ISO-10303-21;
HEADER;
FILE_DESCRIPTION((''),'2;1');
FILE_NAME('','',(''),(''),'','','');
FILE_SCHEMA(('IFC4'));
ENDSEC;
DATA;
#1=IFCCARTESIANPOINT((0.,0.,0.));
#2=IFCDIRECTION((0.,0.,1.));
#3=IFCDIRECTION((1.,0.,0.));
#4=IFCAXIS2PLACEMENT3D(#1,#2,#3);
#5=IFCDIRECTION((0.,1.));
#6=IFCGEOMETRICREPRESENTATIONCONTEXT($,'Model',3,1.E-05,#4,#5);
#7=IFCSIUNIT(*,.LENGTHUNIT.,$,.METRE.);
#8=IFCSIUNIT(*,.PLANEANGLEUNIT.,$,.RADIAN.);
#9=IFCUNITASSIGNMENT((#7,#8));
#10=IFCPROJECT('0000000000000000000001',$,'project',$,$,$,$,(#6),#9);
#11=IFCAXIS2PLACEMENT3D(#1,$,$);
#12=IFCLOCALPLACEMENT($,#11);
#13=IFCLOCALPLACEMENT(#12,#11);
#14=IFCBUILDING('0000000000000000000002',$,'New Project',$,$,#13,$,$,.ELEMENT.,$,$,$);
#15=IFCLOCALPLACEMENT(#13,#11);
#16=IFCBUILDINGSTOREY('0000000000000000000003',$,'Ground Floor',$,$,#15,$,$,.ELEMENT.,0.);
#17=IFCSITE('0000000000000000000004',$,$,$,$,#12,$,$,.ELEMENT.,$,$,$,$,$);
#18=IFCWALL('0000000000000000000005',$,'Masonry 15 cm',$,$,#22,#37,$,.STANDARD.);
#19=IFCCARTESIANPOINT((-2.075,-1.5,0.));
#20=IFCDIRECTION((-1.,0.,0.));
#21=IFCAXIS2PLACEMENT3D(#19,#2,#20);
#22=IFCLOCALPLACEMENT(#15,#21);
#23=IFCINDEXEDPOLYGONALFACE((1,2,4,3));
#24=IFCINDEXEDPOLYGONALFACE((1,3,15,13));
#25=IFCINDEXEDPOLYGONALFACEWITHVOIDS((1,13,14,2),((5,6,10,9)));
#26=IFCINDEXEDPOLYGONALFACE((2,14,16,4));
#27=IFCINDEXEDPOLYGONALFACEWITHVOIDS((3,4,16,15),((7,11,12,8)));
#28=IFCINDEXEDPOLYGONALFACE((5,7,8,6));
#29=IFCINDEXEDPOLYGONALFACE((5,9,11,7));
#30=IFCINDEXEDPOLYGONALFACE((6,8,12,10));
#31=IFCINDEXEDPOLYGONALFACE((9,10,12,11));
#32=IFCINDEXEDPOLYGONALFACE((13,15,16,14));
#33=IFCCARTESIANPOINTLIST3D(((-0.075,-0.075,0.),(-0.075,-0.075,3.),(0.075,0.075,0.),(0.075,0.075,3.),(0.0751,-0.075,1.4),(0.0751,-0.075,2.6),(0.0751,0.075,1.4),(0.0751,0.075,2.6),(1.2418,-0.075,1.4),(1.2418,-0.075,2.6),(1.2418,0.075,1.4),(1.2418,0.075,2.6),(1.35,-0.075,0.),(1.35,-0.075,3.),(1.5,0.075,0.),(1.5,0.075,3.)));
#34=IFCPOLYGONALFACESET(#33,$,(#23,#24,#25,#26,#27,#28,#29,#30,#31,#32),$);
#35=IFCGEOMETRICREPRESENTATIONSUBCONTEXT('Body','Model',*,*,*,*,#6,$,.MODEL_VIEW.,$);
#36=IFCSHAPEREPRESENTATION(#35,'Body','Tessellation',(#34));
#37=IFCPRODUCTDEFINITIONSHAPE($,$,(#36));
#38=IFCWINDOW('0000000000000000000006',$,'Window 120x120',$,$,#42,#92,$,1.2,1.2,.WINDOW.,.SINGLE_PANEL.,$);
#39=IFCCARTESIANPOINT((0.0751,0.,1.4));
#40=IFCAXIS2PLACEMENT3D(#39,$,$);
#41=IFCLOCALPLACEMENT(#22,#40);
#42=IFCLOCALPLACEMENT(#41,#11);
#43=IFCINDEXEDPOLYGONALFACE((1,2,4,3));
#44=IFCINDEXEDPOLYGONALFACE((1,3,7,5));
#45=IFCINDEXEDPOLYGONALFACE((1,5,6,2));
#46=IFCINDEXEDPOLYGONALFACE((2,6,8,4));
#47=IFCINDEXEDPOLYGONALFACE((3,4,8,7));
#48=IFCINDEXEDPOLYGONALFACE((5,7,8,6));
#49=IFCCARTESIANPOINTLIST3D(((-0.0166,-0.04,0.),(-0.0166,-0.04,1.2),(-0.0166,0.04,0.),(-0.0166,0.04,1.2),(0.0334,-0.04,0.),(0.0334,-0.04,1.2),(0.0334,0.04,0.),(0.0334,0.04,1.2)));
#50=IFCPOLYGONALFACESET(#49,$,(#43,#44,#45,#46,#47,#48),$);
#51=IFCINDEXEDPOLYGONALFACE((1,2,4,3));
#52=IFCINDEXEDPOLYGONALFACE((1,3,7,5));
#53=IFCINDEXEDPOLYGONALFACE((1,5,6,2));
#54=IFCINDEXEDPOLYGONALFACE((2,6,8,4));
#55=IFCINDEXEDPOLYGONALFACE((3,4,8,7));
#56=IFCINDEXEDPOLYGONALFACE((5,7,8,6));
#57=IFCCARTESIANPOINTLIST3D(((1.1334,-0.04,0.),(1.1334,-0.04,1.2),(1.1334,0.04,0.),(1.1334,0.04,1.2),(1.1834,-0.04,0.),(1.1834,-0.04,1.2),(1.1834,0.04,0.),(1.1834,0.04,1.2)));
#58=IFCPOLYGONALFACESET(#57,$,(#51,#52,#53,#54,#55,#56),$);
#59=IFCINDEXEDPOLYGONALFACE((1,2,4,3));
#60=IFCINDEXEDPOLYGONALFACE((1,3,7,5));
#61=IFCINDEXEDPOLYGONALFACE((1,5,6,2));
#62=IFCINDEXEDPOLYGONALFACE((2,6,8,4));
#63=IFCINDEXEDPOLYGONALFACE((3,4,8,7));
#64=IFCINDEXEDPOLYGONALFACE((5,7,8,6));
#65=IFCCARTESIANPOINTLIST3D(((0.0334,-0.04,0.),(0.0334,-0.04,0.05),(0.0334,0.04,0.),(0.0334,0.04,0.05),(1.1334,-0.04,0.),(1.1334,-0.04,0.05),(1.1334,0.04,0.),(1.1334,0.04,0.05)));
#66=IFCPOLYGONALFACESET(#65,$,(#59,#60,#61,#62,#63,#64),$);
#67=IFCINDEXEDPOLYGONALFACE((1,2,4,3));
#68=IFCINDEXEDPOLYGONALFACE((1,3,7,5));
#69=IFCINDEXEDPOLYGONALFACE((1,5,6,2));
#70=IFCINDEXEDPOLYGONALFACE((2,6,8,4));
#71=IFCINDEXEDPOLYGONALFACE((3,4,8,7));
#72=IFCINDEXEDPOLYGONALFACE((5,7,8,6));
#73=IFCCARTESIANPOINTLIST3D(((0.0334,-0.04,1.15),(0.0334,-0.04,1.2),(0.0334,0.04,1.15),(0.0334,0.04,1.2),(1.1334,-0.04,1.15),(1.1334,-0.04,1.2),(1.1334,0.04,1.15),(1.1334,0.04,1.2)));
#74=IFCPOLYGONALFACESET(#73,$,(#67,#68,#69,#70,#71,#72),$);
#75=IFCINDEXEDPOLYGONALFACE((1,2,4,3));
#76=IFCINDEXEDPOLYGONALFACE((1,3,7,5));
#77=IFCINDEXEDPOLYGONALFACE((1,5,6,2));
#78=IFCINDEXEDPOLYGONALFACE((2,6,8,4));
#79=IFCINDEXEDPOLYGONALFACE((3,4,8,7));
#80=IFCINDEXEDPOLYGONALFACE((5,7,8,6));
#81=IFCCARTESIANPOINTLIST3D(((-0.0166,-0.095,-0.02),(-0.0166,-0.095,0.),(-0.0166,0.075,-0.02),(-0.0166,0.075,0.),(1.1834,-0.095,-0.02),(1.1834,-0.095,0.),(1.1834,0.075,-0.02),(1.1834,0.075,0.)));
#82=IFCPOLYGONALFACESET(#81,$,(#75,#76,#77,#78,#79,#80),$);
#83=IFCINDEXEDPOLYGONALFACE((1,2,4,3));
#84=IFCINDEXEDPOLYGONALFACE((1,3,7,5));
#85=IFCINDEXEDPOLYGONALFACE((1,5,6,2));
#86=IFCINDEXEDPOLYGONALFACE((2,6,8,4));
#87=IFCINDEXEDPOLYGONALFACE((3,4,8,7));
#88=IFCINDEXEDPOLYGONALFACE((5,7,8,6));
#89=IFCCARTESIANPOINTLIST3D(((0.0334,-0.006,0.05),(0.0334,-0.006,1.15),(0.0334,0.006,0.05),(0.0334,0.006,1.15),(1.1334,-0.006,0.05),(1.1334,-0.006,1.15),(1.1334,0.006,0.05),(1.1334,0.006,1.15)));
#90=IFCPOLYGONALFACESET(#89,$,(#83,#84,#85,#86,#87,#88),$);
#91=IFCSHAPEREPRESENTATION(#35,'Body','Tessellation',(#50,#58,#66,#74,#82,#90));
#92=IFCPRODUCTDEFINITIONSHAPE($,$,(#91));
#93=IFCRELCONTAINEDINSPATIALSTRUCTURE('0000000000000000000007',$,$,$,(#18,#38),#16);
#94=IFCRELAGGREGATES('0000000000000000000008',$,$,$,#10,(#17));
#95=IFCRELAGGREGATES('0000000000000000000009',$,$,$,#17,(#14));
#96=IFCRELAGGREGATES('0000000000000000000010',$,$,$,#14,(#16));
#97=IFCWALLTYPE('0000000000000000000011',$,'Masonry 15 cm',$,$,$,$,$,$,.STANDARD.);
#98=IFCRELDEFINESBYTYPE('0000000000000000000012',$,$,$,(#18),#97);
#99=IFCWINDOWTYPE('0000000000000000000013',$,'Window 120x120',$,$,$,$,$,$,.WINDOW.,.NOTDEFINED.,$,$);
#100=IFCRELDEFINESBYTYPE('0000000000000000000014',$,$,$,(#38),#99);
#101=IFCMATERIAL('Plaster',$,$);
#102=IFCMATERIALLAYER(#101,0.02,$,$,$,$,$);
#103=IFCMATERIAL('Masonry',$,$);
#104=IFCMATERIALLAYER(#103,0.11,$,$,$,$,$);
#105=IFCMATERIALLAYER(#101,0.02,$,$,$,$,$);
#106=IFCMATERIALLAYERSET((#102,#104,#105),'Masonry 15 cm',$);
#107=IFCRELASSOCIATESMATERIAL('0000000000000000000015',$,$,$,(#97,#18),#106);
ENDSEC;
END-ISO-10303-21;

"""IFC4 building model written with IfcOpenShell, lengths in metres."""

from ifc_helpers import new_model, si_unit, direction, frame, frame_2d, origin, origin_with_axes, place, context, subcontext, project, spatial, polyline, rectangle, outline, extrude, material, layer, layer_set, layer_usage, type_object, element, fill, save


model = new_model("IFC4")

# Units and contexts
model_context = context("Model", 3, precision=1e-05, world=origin_with_axes(), true_north=direction((0.0, 1.0)))
body_context = subcontext(model_context, "Body", "Model", "MODEL_VIEW")
ifc_project = project(units=[si_unit("LENGTHUNIT", "METRE"), si_unit("PLANEANGLEUNIT", "RADIAN")], contexts=[model_context])

# Site, building, storey
site_placement = place(None, origin())
site = spatial("IfcSite", under=ifc_project, at=site_placement, CompositionType="ELEMENT")
building_placement = place(site_placement, origin())
building = spatial("IfcBuilding", under=site, at=building_placement, Name="New Project", CompositionType="ELEMENT")
storey_placement = place(building_placement, origin())
storey = spatial("IfcBuildingStorey", under=building, at=storey_placement, Name="Ground Floor", CompositionType="ELEMENT", Elevation=0.0)

# Shared definitions
ifc_material_1 = material(Name="Plaster")
ifc_layer_1 = layer(ifc_material_1, 0.02)
ifc_material_2 = material(Name="Masonry")
ifc_layer_2 = layer(ifc_material_2, 0.11)
ifc_layer_3 = layer(ifc_material_1, 0.02)
ifc_layer_set_1 = layer_set([ifc_layer_1, ifc_layer_2, ifc_layer_3], Name="Masonry 15 cm")
ifc_layer_usage_1 = layer_usage(ifc_layer_set_1, "AXIS2", "NEGATIVE", 0.075)
wall_type = type_object("IfcWallType", Name="Masonry 15 cm", PredefinedType="STANDARD", material=ifc_layer_set_1)
window_type = type_object("IfcWindowType", Name="Window 120x120", PartitioningType="NOTDEFINED", PredefinedType="WINDOW")

# Wall, opening, window
wall_1_placement = place(storey_placement, frame((-2.075, -1.5, 0.0), z_axis=(0.0, 0.0, 1.0), x_axis=(-1.0, 0.0, 0.0)))
wall_1 = element("IfcWall", 1, at=wall_1_placement, inside=storey, type_object=wall_type, material=ifc_layer_usage_1, Name="Masonry 15 cm", PredefinedType="STANDARD", context=body_context, shape_type="SweptSolid", body=[
    extrude(outline(polyline([(-0.075, -0.075), (1.35, -0.075), (1.5, 0.075), (0.075, 0.075), (-0.075, -0.075)])), origin(), (0.0, 0.0, 1.0), 3.0),
])
opening_1_placement = place(wall_1_placement, frame((0.0751, 0.0, 1.4)))
opening_1 = element("IfcOpeningElement", 2, at=opening_1_placement, cuts=wall_1, PredefinedType="OPENING", context=body_context, shape_type="SweptSolid", body=[
    extrude(rectangle(XDim=1.1667, YDim=0.25, at=frame_2d((0.5834, 0.0))), origin(), (0.0, 0.0, 1.0), 1.2),
])
window_1_placement = place(opening_1_placement, origin())
window_1 = element("IfcWindow", 3, at=window_1_placement, inside=storey, type_object=window_type, Name="Window 120x120", OverallHeight=1.2, OverallWidth=1.2, PartitioningType="SINGLE_PANEL", PredefinedType="WINDOW", context=body_context, shape_type="SweptSolid", body=[
    extrude(outline(polyline([(-0.0166, -0.04), (0.0334, -0.04), (0.0334, 0.04), (-0.0166, 0.04), (-0.0166, -0.04)])), origin(), (0.0, 0.0, 1.0), 1.2),
    extrude(outline(polyline([(1.1334, -0.04), (1.1834, -0.04), (1.1834, 0.04), (1.1334, 0.04), (1.1334, -0.04)])), origin(), (0.0, 0.0, 1.0), 1.2),
    extrude(outline(polyline([(0.0334, -0.04), (1.1334, -0.04), (1.1334, 0.04), (0.0334, 0.04), (0.0334, -0.04)])), origin(), (0.0, 0.0, 1.0), 0.05),
    extrude(outline(polyline([(0.0334, -0.04), (1.1334, -0.04), (1.1334, 0.04), (0.0334, 0.04), (0.0334, -0.04)])), frame((0.0, 0.0, 1.15)), (0.0, 0.0, 1.0), 0.05),
    extrude(outline(polyline([(-0.0166, -0.095), (1.1834, -0.095), (1.1834, 0.075), (-0.0166, 0.075), (-0.0166, -0.095)])), frame((0.0, 0.0, -0.02)), (0.0, 0.0, 1.0), 0.02),
    extrude(outline(polyline([(0.0334, -0.006), (1.1334, -0.006), (1.1334, 0.006), (0.0334, 0.006), (0.0334, -0.006)])), frame((0.0, 0.0, 0.05)), (0.0, 0.0, 1.0), 1.1),
])
fill(opening_1, window_1)

save(model, "model.ifc")
